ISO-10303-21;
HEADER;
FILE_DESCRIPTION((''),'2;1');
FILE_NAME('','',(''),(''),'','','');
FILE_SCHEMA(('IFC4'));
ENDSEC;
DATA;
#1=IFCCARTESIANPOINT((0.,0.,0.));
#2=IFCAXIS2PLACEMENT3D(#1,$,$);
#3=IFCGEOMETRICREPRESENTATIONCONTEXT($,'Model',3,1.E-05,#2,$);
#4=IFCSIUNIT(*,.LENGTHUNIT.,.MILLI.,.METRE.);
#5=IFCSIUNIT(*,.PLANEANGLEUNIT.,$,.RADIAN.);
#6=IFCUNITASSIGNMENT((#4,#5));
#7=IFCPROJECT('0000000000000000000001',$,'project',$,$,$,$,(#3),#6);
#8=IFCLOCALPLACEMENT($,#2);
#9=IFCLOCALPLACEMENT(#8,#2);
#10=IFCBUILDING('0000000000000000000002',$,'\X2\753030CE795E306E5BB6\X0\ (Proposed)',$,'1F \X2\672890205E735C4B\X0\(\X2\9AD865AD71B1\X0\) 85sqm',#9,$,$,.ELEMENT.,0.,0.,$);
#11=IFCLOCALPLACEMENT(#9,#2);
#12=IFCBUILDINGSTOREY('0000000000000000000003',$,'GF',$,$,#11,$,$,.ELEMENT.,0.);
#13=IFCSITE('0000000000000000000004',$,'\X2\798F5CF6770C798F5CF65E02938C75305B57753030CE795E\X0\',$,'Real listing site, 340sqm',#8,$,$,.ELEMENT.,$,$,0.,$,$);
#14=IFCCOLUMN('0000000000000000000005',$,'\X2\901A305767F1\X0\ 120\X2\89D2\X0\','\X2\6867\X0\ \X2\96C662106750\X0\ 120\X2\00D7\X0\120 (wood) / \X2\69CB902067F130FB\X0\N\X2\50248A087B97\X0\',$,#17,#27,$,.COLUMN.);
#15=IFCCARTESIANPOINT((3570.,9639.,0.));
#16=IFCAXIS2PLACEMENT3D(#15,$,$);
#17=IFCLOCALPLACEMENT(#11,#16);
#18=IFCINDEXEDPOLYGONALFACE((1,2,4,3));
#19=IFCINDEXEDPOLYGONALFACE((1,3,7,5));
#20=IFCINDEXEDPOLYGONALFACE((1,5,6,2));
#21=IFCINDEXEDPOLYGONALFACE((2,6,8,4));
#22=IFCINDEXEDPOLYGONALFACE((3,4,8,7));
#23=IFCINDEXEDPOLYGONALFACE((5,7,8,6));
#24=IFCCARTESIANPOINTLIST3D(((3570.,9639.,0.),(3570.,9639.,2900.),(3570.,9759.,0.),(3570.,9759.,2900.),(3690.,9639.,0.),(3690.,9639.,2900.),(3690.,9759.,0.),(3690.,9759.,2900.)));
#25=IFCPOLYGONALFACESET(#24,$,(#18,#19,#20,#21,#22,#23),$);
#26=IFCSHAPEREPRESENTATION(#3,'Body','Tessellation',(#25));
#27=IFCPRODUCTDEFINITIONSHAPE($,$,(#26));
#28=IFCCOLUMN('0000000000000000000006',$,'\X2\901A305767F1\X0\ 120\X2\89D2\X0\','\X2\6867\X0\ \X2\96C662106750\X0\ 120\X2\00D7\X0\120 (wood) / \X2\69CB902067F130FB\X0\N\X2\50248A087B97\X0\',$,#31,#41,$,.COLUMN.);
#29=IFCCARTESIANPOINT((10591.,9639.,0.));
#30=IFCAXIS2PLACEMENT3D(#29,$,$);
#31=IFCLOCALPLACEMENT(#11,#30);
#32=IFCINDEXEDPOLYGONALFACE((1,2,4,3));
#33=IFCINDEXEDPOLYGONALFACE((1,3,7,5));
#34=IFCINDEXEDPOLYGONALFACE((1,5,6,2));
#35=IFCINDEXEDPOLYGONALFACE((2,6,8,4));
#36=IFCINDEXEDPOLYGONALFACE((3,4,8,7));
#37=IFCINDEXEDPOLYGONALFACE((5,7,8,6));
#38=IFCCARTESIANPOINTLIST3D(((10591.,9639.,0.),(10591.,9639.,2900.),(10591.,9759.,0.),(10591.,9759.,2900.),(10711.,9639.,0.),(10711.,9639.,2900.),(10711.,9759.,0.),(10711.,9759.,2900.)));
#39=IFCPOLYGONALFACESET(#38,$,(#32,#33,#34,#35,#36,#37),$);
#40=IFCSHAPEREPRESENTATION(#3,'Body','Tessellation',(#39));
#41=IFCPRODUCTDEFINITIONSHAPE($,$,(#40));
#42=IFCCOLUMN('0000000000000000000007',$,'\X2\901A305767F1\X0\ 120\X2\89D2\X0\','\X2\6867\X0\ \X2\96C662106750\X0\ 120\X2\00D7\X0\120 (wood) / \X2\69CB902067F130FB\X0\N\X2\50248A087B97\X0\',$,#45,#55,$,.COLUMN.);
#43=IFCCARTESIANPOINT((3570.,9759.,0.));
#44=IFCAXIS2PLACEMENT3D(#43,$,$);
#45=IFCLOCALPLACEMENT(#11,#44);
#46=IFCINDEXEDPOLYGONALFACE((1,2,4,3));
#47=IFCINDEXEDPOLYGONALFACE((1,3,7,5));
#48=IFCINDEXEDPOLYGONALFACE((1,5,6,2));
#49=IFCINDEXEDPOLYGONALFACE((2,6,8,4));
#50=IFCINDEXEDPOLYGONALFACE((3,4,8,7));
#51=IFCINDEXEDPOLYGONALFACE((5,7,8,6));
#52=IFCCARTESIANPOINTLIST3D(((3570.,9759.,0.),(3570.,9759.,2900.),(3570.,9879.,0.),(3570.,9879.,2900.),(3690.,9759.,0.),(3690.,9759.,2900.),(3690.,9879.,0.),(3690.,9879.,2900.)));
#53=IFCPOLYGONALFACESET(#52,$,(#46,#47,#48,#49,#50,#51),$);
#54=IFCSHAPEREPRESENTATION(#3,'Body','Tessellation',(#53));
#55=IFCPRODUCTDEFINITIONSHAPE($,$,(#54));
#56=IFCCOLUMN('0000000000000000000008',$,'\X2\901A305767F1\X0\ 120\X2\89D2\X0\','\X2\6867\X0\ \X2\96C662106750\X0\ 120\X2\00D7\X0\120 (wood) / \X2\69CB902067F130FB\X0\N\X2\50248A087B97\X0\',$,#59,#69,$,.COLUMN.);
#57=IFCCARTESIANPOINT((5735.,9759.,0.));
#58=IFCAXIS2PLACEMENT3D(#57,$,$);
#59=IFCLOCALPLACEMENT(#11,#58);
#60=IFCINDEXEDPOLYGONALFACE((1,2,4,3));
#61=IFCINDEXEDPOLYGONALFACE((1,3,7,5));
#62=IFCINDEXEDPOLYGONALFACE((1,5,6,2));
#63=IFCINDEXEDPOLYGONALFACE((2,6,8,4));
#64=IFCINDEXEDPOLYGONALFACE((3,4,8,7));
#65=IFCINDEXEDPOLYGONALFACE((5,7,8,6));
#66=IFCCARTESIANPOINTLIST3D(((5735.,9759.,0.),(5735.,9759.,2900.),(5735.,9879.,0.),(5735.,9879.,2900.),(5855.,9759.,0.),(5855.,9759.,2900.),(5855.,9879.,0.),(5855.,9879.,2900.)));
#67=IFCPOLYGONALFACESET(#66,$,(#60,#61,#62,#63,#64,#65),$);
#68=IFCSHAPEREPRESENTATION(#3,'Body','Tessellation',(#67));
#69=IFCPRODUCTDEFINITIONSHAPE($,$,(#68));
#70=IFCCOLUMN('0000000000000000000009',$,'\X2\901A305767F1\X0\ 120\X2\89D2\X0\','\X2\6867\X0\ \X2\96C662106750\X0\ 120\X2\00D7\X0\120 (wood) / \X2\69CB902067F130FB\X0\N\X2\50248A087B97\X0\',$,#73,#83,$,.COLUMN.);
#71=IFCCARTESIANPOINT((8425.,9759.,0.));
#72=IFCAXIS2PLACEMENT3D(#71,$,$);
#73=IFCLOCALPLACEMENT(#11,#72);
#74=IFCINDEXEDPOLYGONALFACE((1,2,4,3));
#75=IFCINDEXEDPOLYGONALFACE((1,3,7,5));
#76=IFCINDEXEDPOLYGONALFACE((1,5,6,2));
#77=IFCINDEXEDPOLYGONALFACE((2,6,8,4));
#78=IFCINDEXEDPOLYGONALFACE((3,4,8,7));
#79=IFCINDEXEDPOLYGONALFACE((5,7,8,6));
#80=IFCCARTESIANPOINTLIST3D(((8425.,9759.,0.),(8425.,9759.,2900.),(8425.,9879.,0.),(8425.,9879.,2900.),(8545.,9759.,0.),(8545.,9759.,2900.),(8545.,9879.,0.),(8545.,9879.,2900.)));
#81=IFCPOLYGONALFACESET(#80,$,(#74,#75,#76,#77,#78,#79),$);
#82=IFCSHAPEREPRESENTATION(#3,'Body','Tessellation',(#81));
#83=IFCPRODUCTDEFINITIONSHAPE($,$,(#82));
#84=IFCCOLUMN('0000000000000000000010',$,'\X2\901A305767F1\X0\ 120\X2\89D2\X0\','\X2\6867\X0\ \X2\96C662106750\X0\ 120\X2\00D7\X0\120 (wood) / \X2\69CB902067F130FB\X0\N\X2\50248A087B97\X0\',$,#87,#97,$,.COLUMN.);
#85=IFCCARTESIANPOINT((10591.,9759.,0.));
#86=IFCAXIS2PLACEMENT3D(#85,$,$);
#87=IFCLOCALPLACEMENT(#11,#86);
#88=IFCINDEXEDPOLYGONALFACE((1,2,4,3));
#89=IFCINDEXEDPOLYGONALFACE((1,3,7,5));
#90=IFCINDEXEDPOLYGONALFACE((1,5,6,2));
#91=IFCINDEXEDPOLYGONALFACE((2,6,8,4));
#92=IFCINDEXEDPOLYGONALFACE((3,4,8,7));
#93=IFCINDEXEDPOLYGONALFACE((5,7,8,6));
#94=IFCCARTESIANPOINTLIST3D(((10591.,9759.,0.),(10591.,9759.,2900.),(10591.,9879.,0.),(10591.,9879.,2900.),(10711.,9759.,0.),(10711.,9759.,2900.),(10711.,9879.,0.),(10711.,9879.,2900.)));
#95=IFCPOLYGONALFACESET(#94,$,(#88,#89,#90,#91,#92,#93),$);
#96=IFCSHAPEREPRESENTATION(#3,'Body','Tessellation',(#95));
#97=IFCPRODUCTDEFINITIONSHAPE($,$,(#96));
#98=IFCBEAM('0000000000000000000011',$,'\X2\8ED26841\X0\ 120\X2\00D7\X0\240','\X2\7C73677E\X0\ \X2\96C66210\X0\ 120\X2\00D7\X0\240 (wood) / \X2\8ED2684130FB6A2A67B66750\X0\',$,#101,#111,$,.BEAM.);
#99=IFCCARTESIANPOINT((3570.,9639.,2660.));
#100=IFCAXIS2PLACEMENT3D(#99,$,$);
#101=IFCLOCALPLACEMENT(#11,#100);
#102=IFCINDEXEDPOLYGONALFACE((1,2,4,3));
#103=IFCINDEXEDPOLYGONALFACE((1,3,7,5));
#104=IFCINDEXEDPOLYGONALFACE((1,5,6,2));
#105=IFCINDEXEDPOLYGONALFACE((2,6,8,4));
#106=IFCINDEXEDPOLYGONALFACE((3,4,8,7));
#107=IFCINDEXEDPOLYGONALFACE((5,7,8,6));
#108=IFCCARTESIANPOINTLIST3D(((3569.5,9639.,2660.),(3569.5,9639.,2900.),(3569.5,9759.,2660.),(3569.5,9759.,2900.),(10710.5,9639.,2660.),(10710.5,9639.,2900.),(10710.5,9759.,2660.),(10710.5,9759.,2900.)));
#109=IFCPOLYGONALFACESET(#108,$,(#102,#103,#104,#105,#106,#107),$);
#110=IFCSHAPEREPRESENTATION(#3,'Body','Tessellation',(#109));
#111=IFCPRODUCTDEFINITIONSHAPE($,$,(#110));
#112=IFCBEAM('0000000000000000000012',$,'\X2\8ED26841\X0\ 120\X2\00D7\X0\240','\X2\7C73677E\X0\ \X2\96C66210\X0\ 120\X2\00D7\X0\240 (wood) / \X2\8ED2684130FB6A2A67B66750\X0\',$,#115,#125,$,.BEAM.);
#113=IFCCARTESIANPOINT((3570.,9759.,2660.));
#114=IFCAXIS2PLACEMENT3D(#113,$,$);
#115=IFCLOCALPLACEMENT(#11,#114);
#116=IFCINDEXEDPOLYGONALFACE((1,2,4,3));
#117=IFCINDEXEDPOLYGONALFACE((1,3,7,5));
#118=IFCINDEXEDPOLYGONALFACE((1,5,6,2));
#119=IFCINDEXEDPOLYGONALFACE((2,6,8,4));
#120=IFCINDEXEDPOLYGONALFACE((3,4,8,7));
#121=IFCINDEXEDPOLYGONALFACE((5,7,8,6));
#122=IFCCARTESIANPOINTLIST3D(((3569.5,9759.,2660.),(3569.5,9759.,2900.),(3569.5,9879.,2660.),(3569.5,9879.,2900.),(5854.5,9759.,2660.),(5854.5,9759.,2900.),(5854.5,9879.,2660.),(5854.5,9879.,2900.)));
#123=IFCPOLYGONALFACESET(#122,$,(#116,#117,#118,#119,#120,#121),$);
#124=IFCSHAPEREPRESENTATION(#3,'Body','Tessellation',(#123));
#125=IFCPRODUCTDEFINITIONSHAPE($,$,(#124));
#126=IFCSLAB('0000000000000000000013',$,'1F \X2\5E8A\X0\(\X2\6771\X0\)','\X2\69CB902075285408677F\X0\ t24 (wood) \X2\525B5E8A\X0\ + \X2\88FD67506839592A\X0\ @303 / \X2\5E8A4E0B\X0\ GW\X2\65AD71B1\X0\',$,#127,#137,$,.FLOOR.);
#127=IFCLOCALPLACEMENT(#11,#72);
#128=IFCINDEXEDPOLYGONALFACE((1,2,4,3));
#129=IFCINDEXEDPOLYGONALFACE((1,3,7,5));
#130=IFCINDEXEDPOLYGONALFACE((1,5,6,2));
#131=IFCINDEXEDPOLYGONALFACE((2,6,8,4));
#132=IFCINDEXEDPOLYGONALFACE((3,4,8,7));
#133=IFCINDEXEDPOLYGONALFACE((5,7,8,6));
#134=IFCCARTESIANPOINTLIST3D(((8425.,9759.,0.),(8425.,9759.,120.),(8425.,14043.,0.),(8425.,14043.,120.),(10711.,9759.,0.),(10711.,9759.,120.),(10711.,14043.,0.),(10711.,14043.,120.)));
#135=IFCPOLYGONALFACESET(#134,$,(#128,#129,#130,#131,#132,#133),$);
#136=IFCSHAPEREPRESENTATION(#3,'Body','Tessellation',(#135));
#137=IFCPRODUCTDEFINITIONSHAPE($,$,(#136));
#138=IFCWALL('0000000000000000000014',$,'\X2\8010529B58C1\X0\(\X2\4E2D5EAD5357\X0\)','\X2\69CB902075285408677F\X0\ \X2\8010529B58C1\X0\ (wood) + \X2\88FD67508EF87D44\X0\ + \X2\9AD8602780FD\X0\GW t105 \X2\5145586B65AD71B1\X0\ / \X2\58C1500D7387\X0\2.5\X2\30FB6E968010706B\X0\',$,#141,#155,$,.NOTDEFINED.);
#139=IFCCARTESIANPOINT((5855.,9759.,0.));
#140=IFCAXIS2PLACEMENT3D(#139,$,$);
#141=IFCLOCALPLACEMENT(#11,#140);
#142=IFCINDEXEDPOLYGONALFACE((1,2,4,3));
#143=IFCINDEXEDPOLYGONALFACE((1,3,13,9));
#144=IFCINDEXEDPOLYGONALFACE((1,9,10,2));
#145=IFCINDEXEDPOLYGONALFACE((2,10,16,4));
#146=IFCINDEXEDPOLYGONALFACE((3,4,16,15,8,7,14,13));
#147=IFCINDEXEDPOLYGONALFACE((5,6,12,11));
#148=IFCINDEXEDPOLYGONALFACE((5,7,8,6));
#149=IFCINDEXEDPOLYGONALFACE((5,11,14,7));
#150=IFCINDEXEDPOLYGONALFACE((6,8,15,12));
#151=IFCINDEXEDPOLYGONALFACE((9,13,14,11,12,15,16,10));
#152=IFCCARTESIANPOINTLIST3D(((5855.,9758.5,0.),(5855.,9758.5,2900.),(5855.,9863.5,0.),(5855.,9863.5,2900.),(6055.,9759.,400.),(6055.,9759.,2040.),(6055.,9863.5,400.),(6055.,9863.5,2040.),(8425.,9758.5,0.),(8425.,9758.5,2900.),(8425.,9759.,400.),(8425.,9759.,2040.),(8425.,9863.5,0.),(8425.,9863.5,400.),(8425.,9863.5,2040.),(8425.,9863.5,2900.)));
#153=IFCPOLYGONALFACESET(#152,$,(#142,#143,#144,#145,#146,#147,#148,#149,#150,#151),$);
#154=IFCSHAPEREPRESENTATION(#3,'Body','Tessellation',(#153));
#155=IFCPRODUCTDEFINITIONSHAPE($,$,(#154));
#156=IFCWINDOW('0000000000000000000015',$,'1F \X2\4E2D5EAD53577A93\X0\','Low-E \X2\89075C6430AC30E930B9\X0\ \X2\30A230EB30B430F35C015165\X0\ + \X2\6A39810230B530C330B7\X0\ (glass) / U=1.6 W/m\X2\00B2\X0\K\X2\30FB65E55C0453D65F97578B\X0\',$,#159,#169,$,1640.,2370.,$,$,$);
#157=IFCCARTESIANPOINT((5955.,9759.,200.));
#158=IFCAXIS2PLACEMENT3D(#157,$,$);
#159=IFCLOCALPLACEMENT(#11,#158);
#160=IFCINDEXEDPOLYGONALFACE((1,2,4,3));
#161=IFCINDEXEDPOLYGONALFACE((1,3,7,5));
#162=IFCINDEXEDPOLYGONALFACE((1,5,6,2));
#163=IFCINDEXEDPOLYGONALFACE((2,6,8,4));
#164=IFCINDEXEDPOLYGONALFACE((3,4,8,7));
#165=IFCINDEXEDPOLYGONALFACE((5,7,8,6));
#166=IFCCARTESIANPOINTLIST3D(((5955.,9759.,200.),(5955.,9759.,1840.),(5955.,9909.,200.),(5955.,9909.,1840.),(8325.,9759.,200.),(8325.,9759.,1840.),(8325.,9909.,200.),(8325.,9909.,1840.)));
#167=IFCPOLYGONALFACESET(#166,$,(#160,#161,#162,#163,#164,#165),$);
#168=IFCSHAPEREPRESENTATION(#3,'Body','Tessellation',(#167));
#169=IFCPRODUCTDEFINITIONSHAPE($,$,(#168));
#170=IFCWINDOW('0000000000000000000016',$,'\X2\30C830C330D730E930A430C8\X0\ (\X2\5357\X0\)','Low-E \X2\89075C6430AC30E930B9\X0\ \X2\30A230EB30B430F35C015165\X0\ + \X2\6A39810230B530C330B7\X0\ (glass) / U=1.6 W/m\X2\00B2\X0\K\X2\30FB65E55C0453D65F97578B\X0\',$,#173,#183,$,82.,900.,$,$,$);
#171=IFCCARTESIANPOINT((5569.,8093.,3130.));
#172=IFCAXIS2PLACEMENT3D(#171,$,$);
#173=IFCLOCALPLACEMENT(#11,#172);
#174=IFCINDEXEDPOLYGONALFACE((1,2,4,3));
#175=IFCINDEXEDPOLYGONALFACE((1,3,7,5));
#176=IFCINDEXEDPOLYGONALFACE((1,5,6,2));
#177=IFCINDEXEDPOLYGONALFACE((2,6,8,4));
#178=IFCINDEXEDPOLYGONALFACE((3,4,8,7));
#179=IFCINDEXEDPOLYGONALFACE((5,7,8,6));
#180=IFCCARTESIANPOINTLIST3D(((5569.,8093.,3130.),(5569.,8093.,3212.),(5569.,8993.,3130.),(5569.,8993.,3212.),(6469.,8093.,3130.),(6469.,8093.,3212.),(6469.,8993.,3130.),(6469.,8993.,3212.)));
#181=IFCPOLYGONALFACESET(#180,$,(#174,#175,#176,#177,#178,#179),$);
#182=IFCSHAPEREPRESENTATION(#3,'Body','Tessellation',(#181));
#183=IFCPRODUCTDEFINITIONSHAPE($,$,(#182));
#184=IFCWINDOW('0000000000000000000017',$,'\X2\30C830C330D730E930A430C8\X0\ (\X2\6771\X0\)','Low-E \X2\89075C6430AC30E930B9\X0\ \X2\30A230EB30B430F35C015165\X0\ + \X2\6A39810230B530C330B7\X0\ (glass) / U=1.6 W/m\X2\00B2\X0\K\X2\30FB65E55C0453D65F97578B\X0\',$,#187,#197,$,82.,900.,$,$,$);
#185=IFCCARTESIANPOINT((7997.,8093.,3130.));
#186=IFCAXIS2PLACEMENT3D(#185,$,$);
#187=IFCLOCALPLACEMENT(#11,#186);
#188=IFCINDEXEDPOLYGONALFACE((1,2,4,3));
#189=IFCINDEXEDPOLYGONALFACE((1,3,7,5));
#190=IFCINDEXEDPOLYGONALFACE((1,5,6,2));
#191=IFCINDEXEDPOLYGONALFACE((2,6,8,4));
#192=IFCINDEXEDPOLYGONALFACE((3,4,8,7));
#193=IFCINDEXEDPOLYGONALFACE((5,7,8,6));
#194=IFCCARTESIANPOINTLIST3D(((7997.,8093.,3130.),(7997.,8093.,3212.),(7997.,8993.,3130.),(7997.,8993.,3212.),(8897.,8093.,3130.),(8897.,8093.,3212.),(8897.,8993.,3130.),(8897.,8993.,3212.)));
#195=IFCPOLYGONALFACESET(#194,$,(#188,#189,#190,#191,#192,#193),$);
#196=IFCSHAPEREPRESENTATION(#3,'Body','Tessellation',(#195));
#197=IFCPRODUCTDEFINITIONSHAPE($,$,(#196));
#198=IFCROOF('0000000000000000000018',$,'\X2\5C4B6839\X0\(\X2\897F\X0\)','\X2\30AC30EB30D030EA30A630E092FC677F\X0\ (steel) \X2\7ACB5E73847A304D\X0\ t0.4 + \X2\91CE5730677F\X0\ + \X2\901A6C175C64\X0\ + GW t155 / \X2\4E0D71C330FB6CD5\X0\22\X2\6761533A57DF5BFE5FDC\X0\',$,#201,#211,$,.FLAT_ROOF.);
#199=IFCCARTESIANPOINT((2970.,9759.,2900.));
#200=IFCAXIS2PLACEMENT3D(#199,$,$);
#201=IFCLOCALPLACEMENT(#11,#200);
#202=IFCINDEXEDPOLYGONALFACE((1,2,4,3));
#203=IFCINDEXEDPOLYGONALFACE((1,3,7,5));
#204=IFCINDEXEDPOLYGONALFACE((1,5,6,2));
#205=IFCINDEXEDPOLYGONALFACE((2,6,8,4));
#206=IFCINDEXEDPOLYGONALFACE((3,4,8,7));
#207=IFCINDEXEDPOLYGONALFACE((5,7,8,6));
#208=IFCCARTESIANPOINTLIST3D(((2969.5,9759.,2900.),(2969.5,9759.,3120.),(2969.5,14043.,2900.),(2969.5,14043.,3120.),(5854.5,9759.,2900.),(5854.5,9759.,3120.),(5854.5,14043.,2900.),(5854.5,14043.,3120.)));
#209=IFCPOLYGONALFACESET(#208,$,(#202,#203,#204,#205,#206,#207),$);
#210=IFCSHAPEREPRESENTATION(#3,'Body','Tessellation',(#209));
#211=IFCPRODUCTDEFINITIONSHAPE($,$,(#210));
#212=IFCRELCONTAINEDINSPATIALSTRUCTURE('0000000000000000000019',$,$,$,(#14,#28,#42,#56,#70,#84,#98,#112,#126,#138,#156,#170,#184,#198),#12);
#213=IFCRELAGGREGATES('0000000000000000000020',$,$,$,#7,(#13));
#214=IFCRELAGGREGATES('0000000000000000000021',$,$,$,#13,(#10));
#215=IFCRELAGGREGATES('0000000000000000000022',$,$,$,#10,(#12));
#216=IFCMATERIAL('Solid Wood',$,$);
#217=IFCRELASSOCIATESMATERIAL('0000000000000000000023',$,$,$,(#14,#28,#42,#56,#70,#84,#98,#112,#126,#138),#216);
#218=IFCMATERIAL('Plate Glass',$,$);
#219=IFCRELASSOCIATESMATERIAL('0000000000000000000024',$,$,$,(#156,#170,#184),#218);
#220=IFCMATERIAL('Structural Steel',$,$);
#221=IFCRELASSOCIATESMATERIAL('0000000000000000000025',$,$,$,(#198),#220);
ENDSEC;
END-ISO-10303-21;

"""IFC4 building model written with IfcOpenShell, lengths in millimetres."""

from ifc_helpers import new_model, si_unit, frame, frame_2d, origin, place, context, project, spatial, rectangle, extrude, material, element, fill, save


model = new_model("IFC4")

# Units and contexts
model_context = context("Model", 3, precision=1e-05, world=origin())
ifc_project = project(units=[si_unit("LENGTHUNIT", "METRE", prefix="MILLI"), si_unit("PLANEANGLEUNIT", "RADIAN")], contexts=[model_context])

# Site, building, storey
site_placement = place(None, origin())
site = spatial("IfcSite", under=ifc_project, at=site_placement, Name="福島県福島市鎌田字田ノ神", ObjectType="Real listing site, 340sqm", CompositionType="ELEMENT", RefElevation=0.0)
building_placement = place(site_placement, origin())
building = spatial("IfcBuilding", under=site, at=building_placement, Name="田ノ神の家 (Proposed)", ObjectType="1F 木造平屋(高断熱) 85sqm", CompositionType="ELEMENT", ElevationOfRefHeight=0.0, ElevationOfTerrain=0.0)
storey_placement = place(building_placement, origin())
storey = spatial("IfcBuildingStorey", under=building, at=storey_placement, Name="GF", CompositionType="ELEMENT", Elevation=0.0)

# Columns
ifc_material_1 = material(Name="Solid Wood")
column_1_placement = place(storey_placement, frame((3570.0, 9639.0, 0.0)))
element("IfcColumn", 1, at=column_1_placement, inside=storey, material=ifc_material_1, Name="通し柱 120角", Description="桧 集成材 120×120 (wood) / 構造柱・N値計算", PredefinedType="COLUMN", context=model_context, shape_type="SweptSolid", body=[
    extrude(rectangle(XDim=120.0, YDim=120.0, at=frame_2d((60.0, 60.0))), frame((3570.0, 9639.0, 0.0)), (0.0, 0.0, 1.0), 2900.0),
])
column_2_placement = place(storey_placement, frame((10591.0, 9639.0, 0.0)))
element("IfcColumn", 2, at=column_2_placement, inside=storey, material=ifc_material_1, Name="通し柱 120角", Description="桧 集成材 120×120 (wood) / 構造柱・N値計算", PredefinedType="COLUMN", context=model_context, shape_type="SweptSolid", body=[
    extrude(rectangle(XDim=120.0, YDim=120.0, at=frame_2d((60.0, 60.0))), frame((10591.0, 9639.0, 0.0)), (0.0, 0.0, 1.0), 2900.0),
])
column_3_placement = place(storey_placement, frame((3570.0, 9759.0, 0.0)))
element("IfcColumn", 3, at=column_3_placement, inside=storey, material=ifc_material_1, Name="通し柱 120角", Description="桧 集成材 120×120 (wood) / 構造柱・N値計算", PredefinedType="COLUMN", context=model_context, shape_type="SweptSolid", body=[
    extrude(rectangle(XDim=120.0, YDim=120.0, at=frame_2d((60.0, 60.0))), frame((3570.0, 9759.0, 0.0)), (0.0, 0.0, 1.0), 2900.0),
])
column_4_placement = place(storey_placement, frame((5735.0, 9759.0, 0.0)))
element("IfcColumn", 4, at=column_4_placement, inside=storey, material=ifc_material_1, Name="通し柱 120角", Description="桧 集成材 120×120 (wood) / 構造柱・N値計算", PredefinedType="COLUMN", context=model_context, shape_type="SweptSolid", body=[
    extrude(rectangle(XDim=120.0, YDim=120.0, at=frame_2d((60.0, 60.0))), frame((5735.0, 9759.0, 0.0)), (0.0, 0.0, 1.0), 2900.0),
])
column_5_placement = place(storey_placement, frame((8425.0, 9759.0, 0.0)))
element("IfcColumn", 5, at=column_5_placement, inside=storey, material=ifc_material_1, Name="通し柱 120角", Description="桧 集成材 120×120 (wood) / 構造柱・N値計算", PredefinedType="COLUMN", context=model_context, shape_type="SweptSolid", body=[
    extrude(rectangle(XDim=120.0, YDim=120.0, at=frame_2d((60.0, 60.0))), frame((8425.0, 9759.0, 0.0)), (0.0, 0.0, 1.0), 2900.0),
])
column_6_placement = place(storey_placement, frame((10591.0, 9759.0, 0.0)))
element("IfcColumn", 6, at=column_6_placement, inside=storey, material=ifc_material_1, Name="通し柱 120角", Description="桧 集成材 120×120 (wood) / 構造柱・N値計算", PredefinedType="COLUMN", context=model_context, shape_type="SweptSolid", body=[
    extrude(rectangle(XDim=120.0, YDim=120.0, at=frame_2d((60.0, 60.0))), frame((10591.0, 9759.0, 0.0)), (0.0, 0.0, 1.0), 2900.0),
])

# Beams
beam_1_placement = place(storey_placement, frame((3570.0, 9639.0, 2660.0)))
element("IfcBeam", 7, at=beam_1_placement, inside=storey, material=ifc_material_1, Name="軒桁 120×240", Description="米松 集成 120×240 (wood) / 軒桁・横架材", PredefinedType="BEAM", context=model_context, shape_type="SweptSolid", body=[
    extrude(rectangle(XDim=7141.0, YDim=120.0, at=frame_2d((3570.0, 60.0))), frame((3570.0, 9639.0, 2660.0)), (0.0, 0.0, 1.0), 240.0),
])
beam_2_placement = place(storey_placement, frame((3570.0, 9759.0, 2660.0)))
element("IfcBeam", 8, at=beam_2_placement, inside=storey, material=ifc_material_1, Name="軒桁 120×240", Description="米松 集成 120×240 (wood) / 軒桁・横架材", PredefinedType="BEAM", context=model_context, shape_type="SweptSolid", body=[
    extrude(rectangle(XDim=2285.0, YDim=120.0, at=frame_2d((1142.0, 60.0))), frame((3570.0, 9759.0, 2660.0)), (0.0, 0.0, 1.0), 240.0),
])

# Slab
slab_1_placement = place(storey_placement, frame((8425.0, 9759.0, 0.0)))
element("IfcSlab", 9, at=slab_1_placement, inside=storey, material=ifc_material_1, Name="1F 床(東)", Description="構造用合板 t24 (wood) 剛床 + 製材根太 @303 / 床下 GW断熱", PredefinedType="FLOOR", context=model_context, shape_type="SweptSolid", body=[
    extrude(rectangle(XDim=2286.0, YDim=4284.0, at=frame_2d((1143.0, 2142.0))), frame((8425.0, 9759.0, 0.0)), (0.0, 0.0, 1.0), 120.0),
])

# Wall, opening, window
wall_1_placement = place(storey_placement, frame((5855.0, 9759.0, 0.0)))
wall_1 = element("IfcWall", 10, at=wall_1_placement, inside=storey, material=ifc_material_1, Name="耐力壁(中庭南)", Description="構造用合板 耐力壁 (wood) + 製材軸組 + 高性能GW t105 充填断熱 / 壁倍率2.5・準耐火", PredefinedType="NOTDEFINED", context=model_context, shape_type="SweptSolid", body=[
    extrude(rectangle(XDim=2570.0, YDim=105.0, at=frame_2d((1285.0, 52.0))), frame((5855.0, 9759.0, 0.0)), (0.0, 0.0, 1.0), 2900.0),
])
opening_placement = place(storey_placement, frame((5955.0, 9759.0, 200.0)))
opening = element("IfcOpeningElement", 11, at=opening_placement, cuts=wall_1, PredefinedType="NOTDEFINED", context=model_context, shape_type="SweptSolid", body=[
    extrude(rectangle(XDim=2370.0, YDim=150.0, at=frame_2d((1185.0, 75.0))), frame((5955.0, 9759.0, 200.0)), (0.0, 0.0, 1.0), 1640.0),
])
ifc_material_2 = material(Name="Plate Glass")
window_1_placement = place(storey_placement, frame((5955.0, 9759.0, 200.0)))
window_1 = element("IfcWindow", 12, at=window_1_placement, inside=storey, material=ifc_material_2, Name="1F 中庭南窓", Description="Low-E 複層ガラス アルゴン封入 + 樹脂サッシ (glass) / U=1.6 W/m²K・日射取得型", OverallHeight=1640.0, OverallWidth=2370.0, context=model_context, shape_type="SweptSolid", body=[
    extrude(rectangle(XDim=2370.0, YDim=150.0, at=frame_2d((1185.0, 75.0))), frame((5955.0, 9759.0, 200.0)), (0.0, 0.0, 1.0), 1640.0),
])
fill(opening, window_1)

# Windows
window_2_placement = place(storey_placement, frame((5569.0, 8093.0, 3130.0)))
element("IfcWindow", 13, at=window_2_placement, inside=storey, material=ifc_material_2, Name="トップライト (南)", Description="Low-E 複層ガラス アルゴン封入 + 樹脂サッシ (glass) / U=1.6 W/m²K・日射取得型", OverallHeight=82.0, OverallWidth=900.0, context=model_context, shape_type="SweptSolid", body=[
    extrude(rectangle(XDim=900.0, YDim=900.0, at=frame_2d((450.0, 450.0))), frame((5569.0, 8093.0, 3130.0)), (0.0, 0.0, 1.0), 82.0),
])
window_3_placement = place(storey_placement, frame((7997.0, 8093.0, 3130.0)))
element("IfcWindow", 14, at=window_3_placement, inside=storey, material=ifc_material_2, Name="トップライト (東)", Description="Low-E 複層ガラス アルゴン封入 + 樹脂サッシ (glass) / U=1.6 W/m²K・日射取得型", OverallHeight=82.0, OverallWidth=900.0, context=model_context, shape_type="SweptSolid", body=[
    extrude(rectangle(XDim=900.0, YDim=900.0, at=frame_2d((450.0, 450.0))), frame((7997.0, 8093.0, 3130.0)), (0.0, 0.0, 1.0), 82.0),
])

# Roof
ifc_material_3 = material(Name="Structural Steel")
roof_1_placement = place(storey_placement, frame((2970.0, 9759.0, 2900.0)))
element("IfcRoof", 15, at=roof_1_placement, inside=storey, material=ifc_material_3, Name="屋根(西)", Description="ガルバリウム鋼板 (steel) 立平葺き t0.4 + 野地板 + 通気層 + GW t155 / 不燃・法22条区域対応", PredefinedType="FLAT_ROOF", context=model_context, shape_type="SweptSolid", body=[
    extrude(rectangle(XDim=2885.0, YDim=4284.0, at=frame_2d((1442.0, 2142.0))), frame((2970.0, 9759.0, 2900.0)), (0.0, 0.0, 1.0), 220.0),
])

save(model, "model.ifc")
